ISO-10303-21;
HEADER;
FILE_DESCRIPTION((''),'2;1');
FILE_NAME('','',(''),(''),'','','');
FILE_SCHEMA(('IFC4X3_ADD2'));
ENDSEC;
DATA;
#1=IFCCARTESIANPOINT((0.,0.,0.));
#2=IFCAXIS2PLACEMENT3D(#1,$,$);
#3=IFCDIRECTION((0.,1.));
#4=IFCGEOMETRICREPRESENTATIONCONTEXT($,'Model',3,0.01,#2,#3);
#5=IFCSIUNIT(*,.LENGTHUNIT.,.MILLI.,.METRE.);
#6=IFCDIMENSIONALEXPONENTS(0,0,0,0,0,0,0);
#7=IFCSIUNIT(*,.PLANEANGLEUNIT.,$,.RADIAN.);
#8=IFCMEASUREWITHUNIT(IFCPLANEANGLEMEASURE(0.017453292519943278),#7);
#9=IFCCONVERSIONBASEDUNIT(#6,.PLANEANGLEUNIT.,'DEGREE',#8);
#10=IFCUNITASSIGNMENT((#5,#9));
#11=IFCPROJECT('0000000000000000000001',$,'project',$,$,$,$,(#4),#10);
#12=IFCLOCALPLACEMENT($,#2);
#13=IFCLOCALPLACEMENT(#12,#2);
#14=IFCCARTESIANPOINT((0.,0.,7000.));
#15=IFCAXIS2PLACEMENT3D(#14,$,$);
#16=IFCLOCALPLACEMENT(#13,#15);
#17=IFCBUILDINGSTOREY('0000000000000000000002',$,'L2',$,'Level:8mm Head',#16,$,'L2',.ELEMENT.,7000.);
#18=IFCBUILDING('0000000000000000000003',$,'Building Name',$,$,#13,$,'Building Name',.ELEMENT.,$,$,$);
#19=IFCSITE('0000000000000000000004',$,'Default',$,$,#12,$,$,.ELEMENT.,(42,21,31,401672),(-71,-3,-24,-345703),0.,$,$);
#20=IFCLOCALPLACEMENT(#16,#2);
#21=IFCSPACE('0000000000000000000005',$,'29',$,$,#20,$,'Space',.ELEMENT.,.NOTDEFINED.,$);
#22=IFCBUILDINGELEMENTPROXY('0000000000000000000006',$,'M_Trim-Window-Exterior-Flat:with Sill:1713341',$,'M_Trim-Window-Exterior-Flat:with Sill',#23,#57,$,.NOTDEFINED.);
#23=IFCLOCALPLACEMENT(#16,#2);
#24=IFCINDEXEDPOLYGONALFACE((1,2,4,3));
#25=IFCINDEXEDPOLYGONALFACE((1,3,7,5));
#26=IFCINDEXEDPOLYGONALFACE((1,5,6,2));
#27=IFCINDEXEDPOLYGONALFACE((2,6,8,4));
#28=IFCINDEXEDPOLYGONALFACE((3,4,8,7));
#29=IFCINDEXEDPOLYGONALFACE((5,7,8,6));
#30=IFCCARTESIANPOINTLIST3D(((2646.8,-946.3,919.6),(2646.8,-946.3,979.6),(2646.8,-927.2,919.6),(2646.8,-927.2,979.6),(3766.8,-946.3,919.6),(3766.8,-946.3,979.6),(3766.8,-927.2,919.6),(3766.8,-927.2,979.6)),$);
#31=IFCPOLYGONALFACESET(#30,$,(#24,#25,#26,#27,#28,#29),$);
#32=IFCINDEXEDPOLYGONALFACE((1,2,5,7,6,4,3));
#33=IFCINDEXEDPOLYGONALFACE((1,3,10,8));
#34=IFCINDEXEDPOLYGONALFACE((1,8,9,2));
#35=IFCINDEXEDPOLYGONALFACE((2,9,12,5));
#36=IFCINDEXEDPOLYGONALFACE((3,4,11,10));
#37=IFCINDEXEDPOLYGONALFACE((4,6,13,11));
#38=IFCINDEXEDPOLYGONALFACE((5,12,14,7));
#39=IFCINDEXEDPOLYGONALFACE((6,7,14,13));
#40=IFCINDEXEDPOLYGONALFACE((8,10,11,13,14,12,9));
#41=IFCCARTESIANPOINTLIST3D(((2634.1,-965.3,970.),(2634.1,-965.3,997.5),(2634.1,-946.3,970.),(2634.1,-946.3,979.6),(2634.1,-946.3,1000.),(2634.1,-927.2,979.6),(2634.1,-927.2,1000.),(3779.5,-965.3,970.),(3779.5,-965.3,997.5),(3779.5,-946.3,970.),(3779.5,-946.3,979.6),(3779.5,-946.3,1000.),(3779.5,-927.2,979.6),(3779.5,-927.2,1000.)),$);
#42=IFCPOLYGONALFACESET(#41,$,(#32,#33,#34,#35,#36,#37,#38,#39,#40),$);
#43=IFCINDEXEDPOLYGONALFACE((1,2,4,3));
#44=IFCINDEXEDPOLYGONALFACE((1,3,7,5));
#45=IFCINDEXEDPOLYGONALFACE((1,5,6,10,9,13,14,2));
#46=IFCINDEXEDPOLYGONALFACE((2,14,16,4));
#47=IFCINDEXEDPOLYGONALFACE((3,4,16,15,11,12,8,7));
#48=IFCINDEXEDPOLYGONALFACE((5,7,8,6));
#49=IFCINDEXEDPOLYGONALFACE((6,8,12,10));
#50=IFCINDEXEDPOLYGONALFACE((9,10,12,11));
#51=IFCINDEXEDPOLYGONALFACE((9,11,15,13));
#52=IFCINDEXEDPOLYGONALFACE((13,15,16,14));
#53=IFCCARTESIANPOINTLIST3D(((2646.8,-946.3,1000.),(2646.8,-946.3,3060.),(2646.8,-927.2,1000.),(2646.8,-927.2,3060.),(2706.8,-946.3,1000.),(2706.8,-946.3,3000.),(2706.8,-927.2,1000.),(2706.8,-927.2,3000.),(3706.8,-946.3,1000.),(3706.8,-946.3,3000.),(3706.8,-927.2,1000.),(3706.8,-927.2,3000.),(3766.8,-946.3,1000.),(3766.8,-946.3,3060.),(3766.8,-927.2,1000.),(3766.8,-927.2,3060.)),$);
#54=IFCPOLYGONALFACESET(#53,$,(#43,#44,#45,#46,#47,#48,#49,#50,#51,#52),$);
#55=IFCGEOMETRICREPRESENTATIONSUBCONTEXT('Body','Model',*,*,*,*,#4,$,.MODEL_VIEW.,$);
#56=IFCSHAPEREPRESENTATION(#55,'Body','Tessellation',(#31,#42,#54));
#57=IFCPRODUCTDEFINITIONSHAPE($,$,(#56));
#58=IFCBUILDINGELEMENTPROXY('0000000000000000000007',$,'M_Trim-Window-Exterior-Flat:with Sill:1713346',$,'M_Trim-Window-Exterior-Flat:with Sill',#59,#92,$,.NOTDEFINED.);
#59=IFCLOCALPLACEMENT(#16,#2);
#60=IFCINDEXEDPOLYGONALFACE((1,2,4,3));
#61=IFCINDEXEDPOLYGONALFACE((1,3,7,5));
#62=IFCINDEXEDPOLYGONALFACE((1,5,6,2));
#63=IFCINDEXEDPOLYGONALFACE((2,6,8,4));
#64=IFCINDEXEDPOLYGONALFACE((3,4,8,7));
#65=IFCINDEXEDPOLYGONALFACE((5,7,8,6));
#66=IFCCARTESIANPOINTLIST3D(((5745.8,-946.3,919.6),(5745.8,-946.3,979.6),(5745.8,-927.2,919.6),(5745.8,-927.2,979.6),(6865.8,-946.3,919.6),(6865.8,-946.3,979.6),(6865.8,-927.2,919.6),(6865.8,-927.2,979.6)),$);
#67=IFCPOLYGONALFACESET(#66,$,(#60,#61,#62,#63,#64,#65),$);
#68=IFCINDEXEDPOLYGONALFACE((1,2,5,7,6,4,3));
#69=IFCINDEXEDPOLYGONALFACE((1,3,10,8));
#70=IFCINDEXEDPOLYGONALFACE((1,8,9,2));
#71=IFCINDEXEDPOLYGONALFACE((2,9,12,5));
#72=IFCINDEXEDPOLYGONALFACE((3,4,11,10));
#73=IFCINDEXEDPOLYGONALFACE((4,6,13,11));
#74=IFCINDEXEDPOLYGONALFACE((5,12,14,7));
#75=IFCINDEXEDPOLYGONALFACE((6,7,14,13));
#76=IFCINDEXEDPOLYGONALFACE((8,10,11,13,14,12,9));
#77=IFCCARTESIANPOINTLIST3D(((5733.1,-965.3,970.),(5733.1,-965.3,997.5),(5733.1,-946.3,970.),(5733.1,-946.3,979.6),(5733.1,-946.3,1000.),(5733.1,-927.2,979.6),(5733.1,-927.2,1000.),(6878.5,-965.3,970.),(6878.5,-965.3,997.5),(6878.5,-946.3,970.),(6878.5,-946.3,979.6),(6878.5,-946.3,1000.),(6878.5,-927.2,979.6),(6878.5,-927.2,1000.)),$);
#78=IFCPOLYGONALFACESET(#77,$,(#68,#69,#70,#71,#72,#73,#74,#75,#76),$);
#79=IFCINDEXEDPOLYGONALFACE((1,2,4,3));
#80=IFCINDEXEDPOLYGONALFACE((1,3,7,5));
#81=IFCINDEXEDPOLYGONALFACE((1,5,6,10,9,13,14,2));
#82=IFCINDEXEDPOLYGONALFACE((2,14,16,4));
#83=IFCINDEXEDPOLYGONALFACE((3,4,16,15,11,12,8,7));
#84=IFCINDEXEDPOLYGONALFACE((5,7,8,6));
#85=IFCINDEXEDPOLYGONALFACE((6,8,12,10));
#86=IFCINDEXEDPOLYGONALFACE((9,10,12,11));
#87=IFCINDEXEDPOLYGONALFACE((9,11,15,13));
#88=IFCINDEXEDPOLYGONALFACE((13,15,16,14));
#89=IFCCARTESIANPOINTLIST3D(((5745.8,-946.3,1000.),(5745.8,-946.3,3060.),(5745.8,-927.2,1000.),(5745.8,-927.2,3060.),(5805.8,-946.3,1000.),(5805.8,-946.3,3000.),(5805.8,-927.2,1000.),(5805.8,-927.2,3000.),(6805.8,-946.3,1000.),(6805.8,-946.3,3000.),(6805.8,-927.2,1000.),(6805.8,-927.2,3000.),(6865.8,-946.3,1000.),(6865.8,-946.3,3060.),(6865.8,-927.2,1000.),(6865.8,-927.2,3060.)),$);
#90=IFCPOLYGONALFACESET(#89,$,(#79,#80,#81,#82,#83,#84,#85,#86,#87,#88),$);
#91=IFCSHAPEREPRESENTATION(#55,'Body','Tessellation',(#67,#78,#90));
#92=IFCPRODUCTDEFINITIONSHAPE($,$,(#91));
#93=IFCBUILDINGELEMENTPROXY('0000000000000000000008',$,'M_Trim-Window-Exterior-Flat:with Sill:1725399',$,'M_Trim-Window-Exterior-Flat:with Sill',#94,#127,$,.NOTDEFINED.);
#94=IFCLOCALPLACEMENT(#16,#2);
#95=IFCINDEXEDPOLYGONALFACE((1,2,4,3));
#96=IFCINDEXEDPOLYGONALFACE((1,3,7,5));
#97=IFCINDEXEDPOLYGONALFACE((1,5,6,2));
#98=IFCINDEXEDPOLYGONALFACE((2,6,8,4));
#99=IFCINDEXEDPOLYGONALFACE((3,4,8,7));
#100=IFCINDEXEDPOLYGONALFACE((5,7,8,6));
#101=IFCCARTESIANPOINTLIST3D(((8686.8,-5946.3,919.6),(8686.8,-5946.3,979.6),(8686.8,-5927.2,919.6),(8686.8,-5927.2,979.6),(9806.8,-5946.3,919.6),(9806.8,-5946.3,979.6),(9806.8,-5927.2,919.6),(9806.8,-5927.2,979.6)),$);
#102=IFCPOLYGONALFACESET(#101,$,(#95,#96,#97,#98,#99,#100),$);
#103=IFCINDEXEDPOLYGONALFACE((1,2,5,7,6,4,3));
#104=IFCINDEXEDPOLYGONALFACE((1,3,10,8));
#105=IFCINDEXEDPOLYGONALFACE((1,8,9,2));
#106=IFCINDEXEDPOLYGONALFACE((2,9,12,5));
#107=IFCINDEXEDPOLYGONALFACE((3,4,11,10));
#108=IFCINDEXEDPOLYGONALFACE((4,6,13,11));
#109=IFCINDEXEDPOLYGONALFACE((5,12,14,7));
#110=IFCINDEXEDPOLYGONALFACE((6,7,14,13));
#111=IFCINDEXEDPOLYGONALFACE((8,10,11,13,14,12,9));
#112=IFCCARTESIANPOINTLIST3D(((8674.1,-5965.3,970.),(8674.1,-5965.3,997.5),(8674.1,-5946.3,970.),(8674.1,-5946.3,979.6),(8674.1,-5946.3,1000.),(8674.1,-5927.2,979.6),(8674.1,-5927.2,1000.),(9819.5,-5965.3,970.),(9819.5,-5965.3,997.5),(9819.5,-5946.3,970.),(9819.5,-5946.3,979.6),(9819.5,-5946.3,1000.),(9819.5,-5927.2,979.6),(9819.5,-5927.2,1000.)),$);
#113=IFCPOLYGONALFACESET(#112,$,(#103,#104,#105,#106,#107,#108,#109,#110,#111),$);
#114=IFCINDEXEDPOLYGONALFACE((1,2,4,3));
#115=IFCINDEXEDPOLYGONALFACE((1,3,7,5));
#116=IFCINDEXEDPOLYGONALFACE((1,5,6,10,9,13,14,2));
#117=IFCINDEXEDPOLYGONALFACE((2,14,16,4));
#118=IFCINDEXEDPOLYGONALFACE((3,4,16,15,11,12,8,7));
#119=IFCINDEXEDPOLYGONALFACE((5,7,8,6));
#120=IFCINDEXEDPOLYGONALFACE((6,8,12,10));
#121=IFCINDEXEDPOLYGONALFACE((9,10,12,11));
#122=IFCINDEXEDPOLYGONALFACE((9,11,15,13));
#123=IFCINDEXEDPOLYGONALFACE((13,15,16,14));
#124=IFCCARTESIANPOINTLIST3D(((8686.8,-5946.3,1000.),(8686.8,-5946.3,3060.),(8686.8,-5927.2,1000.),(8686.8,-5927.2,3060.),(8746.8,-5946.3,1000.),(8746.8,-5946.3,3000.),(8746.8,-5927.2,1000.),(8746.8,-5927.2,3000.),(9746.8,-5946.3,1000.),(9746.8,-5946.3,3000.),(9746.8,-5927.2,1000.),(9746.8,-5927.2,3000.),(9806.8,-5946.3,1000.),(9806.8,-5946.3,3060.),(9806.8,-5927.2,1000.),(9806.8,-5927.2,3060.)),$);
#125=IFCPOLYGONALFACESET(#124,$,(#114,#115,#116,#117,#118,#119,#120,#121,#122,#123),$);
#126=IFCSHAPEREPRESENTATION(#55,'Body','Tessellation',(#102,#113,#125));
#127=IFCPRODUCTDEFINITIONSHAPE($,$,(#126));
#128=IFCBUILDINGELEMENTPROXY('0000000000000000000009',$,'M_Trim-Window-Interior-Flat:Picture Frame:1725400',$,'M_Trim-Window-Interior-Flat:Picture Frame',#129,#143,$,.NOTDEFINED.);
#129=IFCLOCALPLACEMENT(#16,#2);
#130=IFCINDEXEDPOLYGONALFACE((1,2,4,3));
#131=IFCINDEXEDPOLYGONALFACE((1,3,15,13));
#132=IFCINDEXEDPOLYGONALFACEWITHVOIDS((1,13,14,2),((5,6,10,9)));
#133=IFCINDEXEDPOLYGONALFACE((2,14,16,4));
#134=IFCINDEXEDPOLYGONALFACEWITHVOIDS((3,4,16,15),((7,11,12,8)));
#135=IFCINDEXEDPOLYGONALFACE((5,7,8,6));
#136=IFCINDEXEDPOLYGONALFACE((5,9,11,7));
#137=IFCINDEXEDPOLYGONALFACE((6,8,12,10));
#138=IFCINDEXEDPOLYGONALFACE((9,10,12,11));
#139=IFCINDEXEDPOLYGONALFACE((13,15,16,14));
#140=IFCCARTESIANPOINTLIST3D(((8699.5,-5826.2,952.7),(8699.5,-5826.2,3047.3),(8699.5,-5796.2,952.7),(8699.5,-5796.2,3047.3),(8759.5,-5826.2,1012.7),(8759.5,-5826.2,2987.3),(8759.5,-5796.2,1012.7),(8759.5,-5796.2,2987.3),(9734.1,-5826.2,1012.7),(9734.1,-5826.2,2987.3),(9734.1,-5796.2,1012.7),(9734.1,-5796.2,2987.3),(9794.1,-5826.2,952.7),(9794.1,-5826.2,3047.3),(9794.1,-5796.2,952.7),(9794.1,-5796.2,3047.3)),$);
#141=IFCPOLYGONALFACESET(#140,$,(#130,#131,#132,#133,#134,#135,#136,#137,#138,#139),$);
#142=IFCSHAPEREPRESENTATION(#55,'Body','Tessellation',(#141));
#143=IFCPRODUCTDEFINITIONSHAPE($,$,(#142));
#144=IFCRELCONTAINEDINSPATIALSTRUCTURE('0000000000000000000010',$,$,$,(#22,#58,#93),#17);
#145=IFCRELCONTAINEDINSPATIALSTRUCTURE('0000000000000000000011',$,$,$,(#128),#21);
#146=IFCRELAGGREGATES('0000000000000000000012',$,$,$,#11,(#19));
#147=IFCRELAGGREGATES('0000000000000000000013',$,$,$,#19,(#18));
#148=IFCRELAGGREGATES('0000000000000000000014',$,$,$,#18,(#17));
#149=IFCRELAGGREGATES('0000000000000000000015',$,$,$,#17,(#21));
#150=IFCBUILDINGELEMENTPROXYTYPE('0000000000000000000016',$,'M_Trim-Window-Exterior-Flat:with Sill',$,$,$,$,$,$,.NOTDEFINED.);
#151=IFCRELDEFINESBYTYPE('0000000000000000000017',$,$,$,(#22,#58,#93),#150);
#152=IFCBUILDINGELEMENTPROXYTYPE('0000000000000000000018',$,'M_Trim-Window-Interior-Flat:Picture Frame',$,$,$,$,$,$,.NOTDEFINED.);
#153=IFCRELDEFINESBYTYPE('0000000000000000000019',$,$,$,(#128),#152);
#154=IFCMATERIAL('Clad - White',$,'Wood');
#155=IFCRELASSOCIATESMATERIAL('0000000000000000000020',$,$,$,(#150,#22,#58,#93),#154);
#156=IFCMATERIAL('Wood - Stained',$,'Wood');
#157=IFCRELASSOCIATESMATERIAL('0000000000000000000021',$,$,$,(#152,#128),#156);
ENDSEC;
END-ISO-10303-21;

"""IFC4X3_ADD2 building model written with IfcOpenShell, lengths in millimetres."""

from ifc_helpers import new_model, entity, si_unit, converted_unit, direction, frame, frame_2d, origin, place, context, subcontext, project, spatial, polyline, rectangle, outline, extrude, source, transform, mapped, material, type_object, type_shapes, element, save


model = new_model("IFC4X3_ADD2")

# Units and contexts
model_context = context("Model", 3, precision=0.01, world=origin(), true_north=direction((0.0, 1.0)))
body_context = subcontext(model_context, "Body", "Model", "MODEL_VIEW")
ifc_project = project(units=[si_unit("LENGTHUNIT", "METRE", prefix="MILLI"), converted_unit("PLANEANGLEUNIT", "DEGREE", entity("IfcPlaneAngleMeasure", 0.017453292519943278), si_unit("PLANEANGLEUNIT", "RADIAN"), dimensions=[0, 0, 0, 0, 0, 0, 0])], contexts=[model_context])

# Site, building, storey
site_placement = place(None, origin())
site = spatial("IfcSite", under=ifc_project, at=site_placement, Name="Default", CompositionType="ELEMENT", RefLatitude=(42, 21, 31, 401672), RefLongitude=(-71, -3, -24, -345703), RefElevation=0.0)
building_placement = place(site_placement, origin())
building = spatial("IfcBuilding", under=site, at=building_placement, Name="Building Name", LongName="Building Name", CompositionType="ELEMENT")
storey_placement = place(building_placement, frame((0.0, 0.0, 7000.0)))
storey = spatial("IfcBuildingStorey", under=building, at=storey_placement, Name="L2", ObjectType="Level:8mm Head", LongName="L2", CompositionType="ELEMENT", Elevation=7000.0)

# Shared definitions
ifc_material_1 = material(Name="Clad - White", Category="Wood")
ifc_material_2 = material(Name="Wood - Stained", Category="Wood")

# Building element proxies
building_element_proxy_type_1 = type_object("IfcBuildingElementProxyType", Name="M_Trim-Window-Exterior-Flat:with Sill", PredefinedType="NOTDEFINED", material=ifc_material_1)
shared_shape_1 = source(origin(), body_context, "Body", "SweptSolid", [
    extrude(rectangle(XDim=1120.0, YDim=60.0, at=frame_2d((0.0, 0.0), x_axis=(1.0, 0.0))), frame((0.0, -2050.4, 0.0), z_axis=(0.0, 0.0, 1.0), x_axis=(-1.0, 0.0, 0.0)), (0.0, 0.0, 1.0), 19.0),
    extrude(outline(polyline([(-19.0, -15.2), (0.0, -15.2), (0.0, -5.7), (19.0, -5.7), (19.0, 14.8), (0.0, 14.8), (-19.0, 12.3), (-19.0, -15.2)])), frame((-572.7, -2014.8, 19.0), z_axis=(1.0, 0.0, 0.0), x_axis=(0.0, 0.0, -1.0)), (0.0, 0.0, 1.0), 1145.4),
    extrude(outline(polyline([(-1045.0, -560.0), (1015.0, -560.0), (1015.0, -500.0), (-985.0, -500.0), (-985.0, 500.0), (1015.0, 500.0), (1015.0, 560.0), (-1045.0, 560.0), (-1045.0, -560.0)])), frame((0.0, -985.0, 0.0), z_axis=(0.0, 0.0, 1.0), x_axis=(0.0, -1.0, 0.0)), (0.0, 0.0, 1.0), 19.0),
])
type_shapes(building_element_proxy_type_1, [shared_shape_1])
for number, where, z_axis, x_axis, name in (
    (1, (3206.8, -927.2, 3000.0), (0.0, -1.0, 0.0), (1.0, 0.0, 0.0), "M_Trim-Window-Exterior-Flat:with Sill:1713341"),
    (2, (6305.8, -927.2, 3000.0), (0.0, -1.0, 0.0), (1.0, 0.0, 0.0), "M_Trim-Window-Exterior-Flat:with Sill:1713346"),
    (3, (9246.8, -5927.2, 3000.0), (0.0, -1.0, 0.0), (1.0, 0.0, 0.0), "M_Trim-Window-Exterior-Flat:with Sill:1725399"),
):
    element("IfcBuildingElementProxy", number, at=place(storey_placement, frame(where, z_axis=z_axis, x_axis=x_axis)), inside=storey, type_object=building_element_proxy_type_1, material=ifc_material_1, Name=name, ObjectType="M_Trim-Window-Exterior-Flat:with Sill", PredefinedType="NOTDEFINED", context=body_context, shape_type="MappedRepresentation", body=[
        mapped(shared_shape_1, transform((0.0, 0.0, 0.0), scale=1.0)),
    ])

# Shared definitions
space_1_placement = place(storey_placement, origin())
space_1 = spatial("IfcSpace", under=storey, at=space_1_placement, Name="29", LongName="Space", CompositionType="ELEMENT", PredefinedType="NOTDEFINED")

# Building element proxy
building_element_proxy_type_2 = type_object("IfcBuildingElementProxyType", Name="M_Trim-Window-Interior-Flat:Picture Frame", PredefinedType="NOTDEFINED", material=ifc_material_2)
shared_shape_2 = source(origin(), body_context, "Body", "SweptSolid", [
    extrude(outline(polyline([(-547.3, -1047.3), (547.3, -1047.3), (547.3, 1047.3), (-547.3, 1047.3), (-547.3, -1047.3)]), holes=[polyline([(-487.3, -987.3), (-487.3, 987.3), (487.3, 987.3), (487.3, -987.3), (-487.3, -987.3)])]), frame((0.0, -1000.0, 0.0), z_axis=(0.0, 0.0, 1.0), x_axis=(-1.0, 0.0, 0.0)), (0.0, 0.0, 1.0), 30.0),
])
type_shapes(building_element_proxy_type_2, [shared_shape_2])
proxy_1_placement = place(space_1_placement, frame((9246.8, -5826.2, 3000.0), z_axis=(0.0, 1.0, 0.0), x_axis=(-1.0, 0.0, 0.0)))
element("IfcBuildingElementProxy", 4, at=proxy_1_placement, inside=space_1, type_object=building_element_proxy_type_2, material=ifc_material_2, Name="M_Trim-Window-Interior-Flat:Picture Frame:1725400", ObjectType="M_Trim-Window-Interior-Flat:Picture Frame", PredefinedType="NOTDEFINED", context=body_context, shape_type="MappedRepresentation", body=[
    mapped(shared_shape_2, transform((0.0, 0.0, 0.0), scale=1.0)),
])

save(model, "model.ifc")
